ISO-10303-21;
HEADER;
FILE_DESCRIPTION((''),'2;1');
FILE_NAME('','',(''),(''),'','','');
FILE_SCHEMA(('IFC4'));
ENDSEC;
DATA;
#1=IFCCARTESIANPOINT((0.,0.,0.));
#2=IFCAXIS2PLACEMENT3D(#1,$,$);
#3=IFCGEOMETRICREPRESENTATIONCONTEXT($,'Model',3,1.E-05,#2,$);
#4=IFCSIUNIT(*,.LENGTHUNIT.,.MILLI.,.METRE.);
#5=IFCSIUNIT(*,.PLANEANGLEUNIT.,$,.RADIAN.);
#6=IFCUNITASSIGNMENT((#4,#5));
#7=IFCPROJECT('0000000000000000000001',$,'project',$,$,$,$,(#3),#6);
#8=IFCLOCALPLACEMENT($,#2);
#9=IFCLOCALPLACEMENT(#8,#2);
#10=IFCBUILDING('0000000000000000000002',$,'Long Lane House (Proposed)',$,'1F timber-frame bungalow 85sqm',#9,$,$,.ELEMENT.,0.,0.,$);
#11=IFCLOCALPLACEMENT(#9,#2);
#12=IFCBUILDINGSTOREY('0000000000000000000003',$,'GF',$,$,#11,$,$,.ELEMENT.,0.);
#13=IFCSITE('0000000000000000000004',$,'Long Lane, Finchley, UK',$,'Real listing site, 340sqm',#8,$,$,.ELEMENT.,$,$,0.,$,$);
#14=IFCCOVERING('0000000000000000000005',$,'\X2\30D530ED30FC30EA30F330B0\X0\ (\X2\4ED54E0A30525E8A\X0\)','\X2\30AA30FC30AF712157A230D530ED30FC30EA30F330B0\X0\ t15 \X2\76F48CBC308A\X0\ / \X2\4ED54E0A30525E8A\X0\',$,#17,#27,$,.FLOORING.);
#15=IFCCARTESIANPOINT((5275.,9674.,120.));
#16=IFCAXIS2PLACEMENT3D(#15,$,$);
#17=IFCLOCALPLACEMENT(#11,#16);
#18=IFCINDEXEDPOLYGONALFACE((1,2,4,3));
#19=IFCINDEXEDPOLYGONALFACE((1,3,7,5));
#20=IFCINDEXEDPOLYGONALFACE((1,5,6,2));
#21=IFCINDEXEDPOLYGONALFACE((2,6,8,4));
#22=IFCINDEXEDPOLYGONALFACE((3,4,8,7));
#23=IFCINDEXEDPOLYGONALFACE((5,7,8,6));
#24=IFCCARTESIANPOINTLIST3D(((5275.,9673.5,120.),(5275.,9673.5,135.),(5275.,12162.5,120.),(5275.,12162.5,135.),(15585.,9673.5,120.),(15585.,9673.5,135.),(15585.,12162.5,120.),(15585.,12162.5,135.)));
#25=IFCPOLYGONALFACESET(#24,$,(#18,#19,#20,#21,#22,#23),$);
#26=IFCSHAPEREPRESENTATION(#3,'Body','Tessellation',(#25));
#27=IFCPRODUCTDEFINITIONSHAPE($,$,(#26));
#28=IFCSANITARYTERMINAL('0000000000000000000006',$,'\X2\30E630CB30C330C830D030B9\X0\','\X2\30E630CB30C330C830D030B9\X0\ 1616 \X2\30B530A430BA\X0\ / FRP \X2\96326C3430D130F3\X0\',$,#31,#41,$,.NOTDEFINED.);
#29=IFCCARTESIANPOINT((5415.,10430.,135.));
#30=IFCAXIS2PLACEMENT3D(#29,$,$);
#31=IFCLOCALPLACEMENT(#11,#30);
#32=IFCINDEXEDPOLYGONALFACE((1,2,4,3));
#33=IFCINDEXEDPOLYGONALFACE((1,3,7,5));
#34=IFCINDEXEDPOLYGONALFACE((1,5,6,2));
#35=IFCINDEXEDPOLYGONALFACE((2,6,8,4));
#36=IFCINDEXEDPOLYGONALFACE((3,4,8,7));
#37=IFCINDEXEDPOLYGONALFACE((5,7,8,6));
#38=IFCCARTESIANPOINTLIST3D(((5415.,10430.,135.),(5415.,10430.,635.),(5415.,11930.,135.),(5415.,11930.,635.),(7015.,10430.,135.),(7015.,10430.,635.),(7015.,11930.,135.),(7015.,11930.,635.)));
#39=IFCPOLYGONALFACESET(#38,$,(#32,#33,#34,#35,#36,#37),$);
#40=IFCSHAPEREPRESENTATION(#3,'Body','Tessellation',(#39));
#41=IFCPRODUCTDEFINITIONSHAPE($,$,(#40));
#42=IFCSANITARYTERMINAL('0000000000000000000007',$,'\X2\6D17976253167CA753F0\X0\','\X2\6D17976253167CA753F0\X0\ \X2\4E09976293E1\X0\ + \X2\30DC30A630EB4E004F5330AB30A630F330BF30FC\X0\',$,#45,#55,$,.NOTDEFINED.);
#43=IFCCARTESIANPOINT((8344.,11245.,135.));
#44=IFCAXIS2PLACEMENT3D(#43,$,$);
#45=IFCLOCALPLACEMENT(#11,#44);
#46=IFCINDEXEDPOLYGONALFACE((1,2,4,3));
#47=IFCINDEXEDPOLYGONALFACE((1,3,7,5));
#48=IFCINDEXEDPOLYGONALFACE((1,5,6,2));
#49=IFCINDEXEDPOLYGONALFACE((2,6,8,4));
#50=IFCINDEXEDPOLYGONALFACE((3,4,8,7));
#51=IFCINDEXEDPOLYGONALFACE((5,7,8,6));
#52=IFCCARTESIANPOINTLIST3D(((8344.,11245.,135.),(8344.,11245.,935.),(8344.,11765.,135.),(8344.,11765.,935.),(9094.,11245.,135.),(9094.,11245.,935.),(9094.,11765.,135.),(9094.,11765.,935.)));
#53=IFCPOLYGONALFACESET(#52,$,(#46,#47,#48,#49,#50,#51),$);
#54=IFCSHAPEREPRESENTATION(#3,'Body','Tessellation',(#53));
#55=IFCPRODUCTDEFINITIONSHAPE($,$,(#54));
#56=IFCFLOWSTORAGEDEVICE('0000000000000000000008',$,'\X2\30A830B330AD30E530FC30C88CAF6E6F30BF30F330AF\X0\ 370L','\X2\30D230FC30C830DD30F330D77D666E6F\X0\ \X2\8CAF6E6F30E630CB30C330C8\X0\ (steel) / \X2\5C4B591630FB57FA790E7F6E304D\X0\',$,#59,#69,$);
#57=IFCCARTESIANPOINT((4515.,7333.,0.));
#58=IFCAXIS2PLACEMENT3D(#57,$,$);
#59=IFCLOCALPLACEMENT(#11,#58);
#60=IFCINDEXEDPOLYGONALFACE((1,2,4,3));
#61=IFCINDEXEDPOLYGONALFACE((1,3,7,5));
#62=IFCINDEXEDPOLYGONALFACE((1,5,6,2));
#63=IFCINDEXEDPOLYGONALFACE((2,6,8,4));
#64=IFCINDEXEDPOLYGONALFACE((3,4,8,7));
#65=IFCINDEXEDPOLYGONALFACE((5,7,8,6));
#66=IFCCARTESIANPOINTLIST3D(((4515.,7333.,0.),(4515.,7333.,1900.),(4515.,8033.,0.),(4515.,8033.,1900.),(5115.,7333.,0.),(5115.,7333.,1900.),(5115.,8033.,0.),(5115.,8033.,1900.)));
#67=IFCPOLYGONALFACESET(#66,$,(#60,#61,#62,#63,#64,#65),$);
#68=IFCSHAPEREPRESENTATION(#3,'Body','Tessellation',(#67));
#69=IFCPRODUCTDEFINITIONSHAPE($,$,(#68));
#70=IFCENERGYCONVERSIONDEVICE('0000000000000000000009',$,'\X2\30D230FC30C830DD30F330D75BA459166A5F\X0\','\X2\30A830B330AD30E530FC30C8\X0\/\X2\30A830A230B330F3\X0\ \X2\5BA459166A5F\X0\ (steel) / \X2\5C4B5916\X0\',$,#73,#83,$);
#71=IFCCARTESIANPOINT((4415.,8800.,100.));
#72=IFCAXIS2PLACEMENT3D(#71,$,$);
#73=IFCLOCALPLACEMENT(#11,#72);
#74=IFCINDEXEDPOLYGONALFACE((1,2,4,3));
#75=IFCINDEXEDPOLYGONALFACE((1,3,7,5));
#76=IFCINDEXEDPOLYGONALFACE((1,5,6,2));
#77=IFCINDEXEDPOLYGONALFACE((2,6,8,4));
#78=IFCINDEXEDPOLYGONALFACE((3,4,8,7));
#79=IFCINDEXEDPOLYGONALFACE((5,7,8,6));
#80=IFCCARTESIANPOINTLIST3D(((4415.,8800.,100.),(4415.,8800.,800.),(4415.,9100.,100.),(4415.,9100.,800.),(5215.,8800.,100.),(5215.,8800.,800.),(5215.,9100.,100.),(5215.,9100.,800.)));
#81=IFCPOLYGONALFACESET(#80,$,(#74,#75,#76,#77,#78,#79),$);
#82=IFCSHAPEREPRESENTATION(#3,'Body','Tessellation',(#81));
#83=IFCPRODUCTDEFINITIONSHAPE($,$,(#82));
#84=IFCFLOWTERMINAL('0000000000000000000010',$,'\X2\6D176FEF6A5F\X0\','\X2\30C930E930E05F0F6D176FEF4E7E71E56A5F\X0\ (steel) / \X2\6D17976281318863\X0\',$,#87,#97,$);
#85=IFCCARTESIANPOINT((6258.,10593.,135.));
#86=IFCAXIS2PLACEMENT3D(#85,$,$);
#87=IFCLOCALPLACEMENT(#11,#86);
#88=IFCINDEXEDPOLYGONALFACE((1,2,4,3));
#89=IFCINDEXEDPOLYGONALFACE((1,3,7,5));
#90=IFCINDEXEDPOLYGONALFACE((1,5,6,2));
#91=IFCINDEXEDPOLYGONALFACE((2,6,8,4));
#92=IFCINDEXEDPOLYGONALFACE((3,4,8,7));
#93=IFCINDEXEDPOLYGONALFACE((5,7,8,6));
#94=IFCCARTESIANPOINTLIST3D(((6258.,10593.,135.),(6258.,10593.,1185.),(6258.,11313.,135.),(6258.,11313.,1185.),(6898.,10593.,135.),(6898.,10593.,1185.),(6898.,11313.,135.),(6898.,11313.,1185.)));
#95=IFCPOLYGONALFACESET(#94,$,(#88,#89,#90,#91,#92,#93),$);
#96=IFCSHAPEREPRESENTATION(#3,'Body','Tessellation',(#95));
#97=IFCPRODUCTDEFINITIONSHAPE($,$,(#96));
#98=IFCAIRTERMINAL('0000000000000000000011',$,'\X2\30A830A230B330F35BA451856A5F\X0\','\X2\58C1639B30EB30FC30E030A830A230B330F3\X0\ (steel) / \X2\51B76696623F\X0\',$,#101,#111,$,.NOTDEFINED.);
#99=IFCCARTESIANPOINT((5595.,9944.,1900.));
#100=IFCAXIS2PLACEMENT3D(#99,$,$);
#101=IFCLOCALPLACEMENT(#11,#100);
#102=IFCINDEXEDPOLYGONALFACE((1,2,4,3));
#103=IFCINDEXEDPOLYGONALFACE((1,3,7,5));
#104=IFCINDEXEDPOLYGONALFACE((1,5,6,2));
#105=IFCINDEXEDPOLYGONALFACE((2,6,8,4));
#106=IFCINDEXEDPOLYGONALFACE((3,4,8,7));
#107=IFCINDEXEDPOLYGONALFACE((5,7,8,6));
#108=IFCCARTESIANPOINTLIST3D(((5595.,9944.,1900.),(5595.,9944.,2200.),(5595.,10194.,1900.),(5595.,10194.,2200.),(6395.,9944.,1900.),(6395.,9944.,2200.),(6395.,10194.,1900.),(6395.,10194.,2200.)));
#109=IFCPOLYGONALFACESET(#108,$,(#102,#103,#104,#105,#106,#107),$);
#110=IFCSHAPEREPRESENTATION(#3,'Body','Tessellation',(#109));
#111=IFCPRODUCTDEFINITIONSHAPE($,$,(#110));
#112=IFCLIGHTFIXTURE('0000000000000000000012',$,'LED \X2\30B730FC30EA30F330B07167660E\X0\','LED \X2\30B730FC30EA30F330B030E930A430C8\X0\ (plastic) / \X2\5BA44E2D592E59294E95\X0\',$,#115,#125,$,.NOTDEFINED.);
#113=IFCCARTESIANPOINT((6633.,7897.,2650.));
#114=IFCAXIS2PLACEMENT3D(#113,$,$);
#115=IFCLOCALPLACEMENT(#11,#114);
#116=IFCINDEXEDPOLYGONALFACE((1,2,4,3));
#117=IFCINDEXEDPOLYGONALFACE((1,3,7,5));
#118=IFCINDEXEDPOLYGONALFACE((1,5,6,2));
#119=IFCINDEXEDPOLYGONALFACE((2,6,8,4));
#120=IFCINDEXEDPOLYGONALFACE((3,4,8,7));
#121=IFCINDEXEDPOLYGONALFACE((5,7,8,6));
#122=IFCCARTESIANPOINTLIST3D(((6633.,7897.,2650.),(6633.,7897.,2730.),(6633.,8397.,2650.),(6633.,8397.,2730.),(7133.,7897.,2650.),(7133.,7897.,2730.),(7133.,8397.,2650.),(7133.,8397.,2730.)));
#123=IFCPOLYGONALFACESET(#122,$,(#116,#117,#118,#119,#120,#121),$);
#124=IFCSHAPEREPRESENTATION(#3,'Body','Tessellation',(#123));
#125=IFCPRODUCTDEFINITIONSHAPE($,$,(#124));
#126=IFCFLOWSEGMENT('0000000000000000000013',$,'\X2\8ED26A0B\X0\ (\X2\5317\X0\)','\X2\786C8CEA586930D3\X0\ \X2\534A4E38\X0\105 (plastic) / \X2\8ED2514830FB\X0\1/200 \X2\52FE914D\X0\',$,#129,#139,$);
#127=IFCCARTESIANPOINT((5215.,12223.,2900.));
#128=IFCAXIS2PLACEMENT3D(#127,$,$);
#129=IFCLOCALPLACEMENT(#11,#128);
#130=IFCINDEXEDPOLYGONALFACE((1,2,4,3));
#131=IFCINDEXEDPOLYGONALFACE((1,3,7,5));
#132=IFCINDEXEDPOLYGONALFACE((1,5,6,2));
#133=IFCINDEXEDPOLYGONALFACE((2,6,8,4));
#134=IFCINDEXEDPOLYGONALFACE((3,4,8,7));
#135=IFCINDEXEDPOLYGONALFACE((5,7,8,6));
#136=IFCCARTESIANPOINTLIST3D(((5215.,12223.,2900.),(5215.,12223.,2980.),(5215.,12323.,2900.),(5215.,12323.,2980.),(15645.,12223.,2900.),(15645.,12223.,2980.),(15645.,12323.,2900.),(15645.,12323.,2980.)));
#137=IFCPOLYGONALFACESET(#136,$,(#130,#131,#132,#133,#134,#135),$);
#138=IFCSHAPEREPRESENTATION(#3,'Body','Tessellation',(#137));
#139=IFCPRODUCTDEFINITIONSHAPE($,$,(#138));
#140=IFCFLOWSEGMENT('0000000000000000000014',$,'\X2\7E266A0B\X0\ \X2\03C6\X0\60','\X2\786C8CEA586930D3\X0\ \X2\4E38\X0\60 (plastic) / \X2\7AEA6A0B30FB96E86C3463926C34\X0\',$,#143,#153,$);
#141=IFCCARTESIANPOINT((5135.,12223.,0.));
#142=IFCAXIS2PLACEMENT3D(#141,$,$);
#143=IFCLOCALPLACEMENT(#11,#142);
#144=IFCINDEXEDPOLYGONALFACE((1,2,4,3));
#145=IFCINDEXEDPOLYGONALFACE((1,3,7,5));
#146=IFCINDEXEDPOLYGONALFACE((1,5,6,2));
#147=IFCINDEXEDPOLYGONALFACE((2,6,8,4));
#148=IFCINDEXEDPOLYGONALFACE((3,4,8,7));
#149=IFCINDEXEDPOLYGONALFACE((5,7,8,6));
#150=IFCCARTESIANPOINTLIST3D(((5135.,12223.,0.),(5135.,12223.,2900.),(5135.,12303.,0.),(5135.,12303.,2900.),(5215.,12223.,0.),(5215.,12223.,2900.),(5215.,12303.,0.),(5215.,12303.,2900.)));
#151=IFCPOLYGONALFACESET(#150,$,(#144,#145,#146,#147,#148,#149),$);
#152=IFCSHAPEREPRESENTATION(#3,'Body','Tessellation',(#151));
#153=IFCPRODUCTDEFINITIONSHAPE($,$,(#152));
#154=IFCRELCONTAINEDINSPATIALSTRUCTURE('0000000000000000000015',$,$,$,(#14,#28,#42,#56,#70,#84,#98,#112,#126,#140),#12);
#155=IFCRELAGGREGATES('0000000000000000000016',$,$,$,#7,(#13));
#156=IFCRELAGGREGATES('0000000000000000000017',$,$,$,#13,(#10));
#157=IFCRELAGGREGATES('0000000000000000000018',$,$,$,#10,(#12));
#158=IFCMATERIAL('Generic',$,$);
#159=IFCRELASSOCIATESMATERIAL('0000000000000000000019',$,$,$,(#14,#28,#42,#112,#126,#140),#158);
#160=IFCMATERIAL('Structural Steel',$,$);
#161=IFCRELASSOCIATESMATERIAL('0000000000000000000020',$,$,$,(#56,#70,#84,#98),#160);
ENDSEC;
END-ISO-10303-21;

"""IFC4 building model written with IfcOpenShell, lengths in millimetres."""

from ifc_helpers import new_model, si_unit, frame, frame_2d, origin, place, context, project, spatial, rectangle, extrude, material, element, save


model = new_model("IFC4")

# Units and contexts
model_context = context("Model", 3, precision=1e-05, world=origin())
ifc_project = project(units=[si_unit("LENGTHUNIT", "METRE", prefix="MILLI"), si_unit("PLANEANGLEUNIT", "RADIAN")], contexts=[model_context])

# Site, building, storey
site_placement = place(None, origin())
site = spatial("IfcSite", under=ifc_project, at=site_placement, Name="Long Lane, Finchley, UK", ObjectType="Real listing site, 340sqm", CompositionType="ELEMENT", RefElevation=0.0)
building_placement = place(site_placement, origin())
building = spatial("IfcBuilding", under=site, at=building_placement, Name="Long Lane House (Proposed)", ObjectType="1F timber-frame bungalow 85sqm", CompositionType="ELEMENT", ElevationOfRefHeight=0.0, ElevationOfTerrain=0.0)
storey_placement = place(building_placement, origin())
storey = spatial("IfcBuildingStorey", under=building, at=storey_placement, Name="GF", CompositionType="ELEMENT", Elevation=0.0)

# Shared definitions
ifc_material_1 = material(Name="Structural Steel")

# Covering
ifc_material_2 = material(Name="Generic")
covering_1_placement = place(storey_placement, frame((5275.0, 9674.0, 120.0)))
element("IfcCovering", 1, at=covering_1_placement, inside=storey, material=ifc_material_2, Name="フローリング (仕上げ床)", Description="オーク無垢フローリング t15 直貼り / 仕上げ床", PredefinedType="FLOORING", context=model_context, shape_type="SweptSolid", body=[
    extrude(rectangle(XDim=10310.0, YDim=2489.0, at=frame_2d((5155.0, 1244.0))), frame((5275.0, 9674.0, 120.0)), (0.0, 0.0, 1.0), 15.0),
])

# Sanitary terminals
sanitary_terminal_1_placement = place(storey_placement, frame((5415.0, 10430.0, 135.0)))
element("IfcSanitaryTerminal", 2, at=sanitary_terminal_1_placement, inside=storey, material=ifc_material_2, Name="ユニットバス", Description="ユニットバス 1616 サイズ / FRP 防水パン", PredefinedType="NOTDEFINED", context=model_context, shape_type="SweptSolid", body=[
    extrude(rectangle(XDim=1600.0, YDim=1500.0, at=frame_2d((800.0, 750.0))), frame((5415.0, 10430.0, 135.0)), (0.0, 0.0, 1.0), 500.0),
])
sanitary_terminal_2_placement = place(storey_placement, frame((8344.0, 11245.0, 135.0)))
element("IfcSanitaryTerminal", 3, at=sanitary_terminal_2_placement, inside=storey, material=ifc_material_2, Name="洗面化粧台", Description="洗面化粧台 三面鏡 + ボウル一体カウンター", PredefinedType="NOTDEFINED", context=model_context, shape_type="SweptSolid", body=[
    extrude(rectangle(XDim=750.0, YDim=520.0, at=frame_2d((375.0, 260.0))), frame((8344.0, 11245.0, 135.0)), (0.0, 0.0, 1.0), 800.0),
])

# Flow storage device
flow_storage_device_placement = place(storey_placement, frame((4515.0, 7333.0, 0.0)))
element("IfcFlowStorageDevice", 4, at=flow_storage_device_placement, inside=storey, material=ifc_material_1, Name="エコキュート貯湯タンク 370L", Description="ヒートポンプ給湯 貯湯ユニット (steel) / 屋外・基礎置き", context=model_context, shape_type="SweptSolid", body=[
    extrude(rectangle(XDim=600.0, YDim=700.0, at=frame_2d((300.0, 350.0))), frame((4515.0, 7333.0, 0.0)), (0.0, 0.0, 1.0), 1900.0),
])

# Energy conversion device
energy_conversion_device_placement = place(storey_placement, frame((4415.0, 8800.0, 100.0)))
element("IfcEnergyConversionDevice", 5, at=energy_conversion_device_placement, inside=storey, material=ifc_material_1, Name="ヒートポンプ室外機", Description="エコキュート/エアコン 室外機 (steel) / 屋外", context=model_context, shape_type="SweptSolid", body=[
    extrude(rectangle(XDim=800.0, YDim=300.0, at=frame_2d((400.0, 150.0))), frame((4415.0, 8800.0, 100.0)), (0.0, 0.0, 1.0), 700.0),
])

# Flow terminal
flow_terminal_placement = place(storey_placement, frame((6258.0, 10593.0, 135.0)))
element("IfcFlowTerminal", 6, at=flow_terminal_placement, inside=storey, material=ifc_material_1, Name="洗濯機", Description="ドラム式洗濯乾燥機 (steel) / 洗面脱衣", context=model_context, shape_type="SweptSolid", body=[
    extrude(rectangle(XDim=640.0, YDim=720.0, at=frame_2d((320.0, 360.0))), frame((6258.0, 10593.0, 135.0)), (0.0, 0.0, 1.0), 1050.0),
])

# Air terminal
air_terminal_placement = place(storey_placement, frame((5595.0, 9944.0, 1900.0)))
element("IfcAirTerminal", 7, at=air_terminal_placement, inside=storey, material=ifc_material_1, Name="エアコン室内機", Description="壁掛ルームエアコン (steel) / 冷暖房", PredefinedType="NOTDEFINED", context=model_context, shape_type="SweptSolid", body=[
    extrude(rectangle(XDim=800.0, YDim=250.0, at=frame_2d((400.0, 125.0))), frame((5595.0, 9944.0, 1900.0)), (0.0, 0.0, 1.0), 300.0),
])

# Light fixture
light_fixture_placement = place(storey_placement, frame((6633.0, 7897.0, 2650.0)))
element("IfcLightFixture", 8, at=light_fixture_placement, inside=storey, material=ifc_material_2, Name="LED シーリング照明", Description="LED シーリングライト (plastic) / 室中央天井", PredefinedType="NOTDEFINED", context=model_context, shape_type="SweptSolid", body=[
    extrude(rectangle(XDim=500.0, YDim=500.0, at=frame_2d((250.0, 250.0))), frame((6633.0, 7897.0, 2650.0)), (0.0, 0.0, 1.0), 80.0),
])

# Flow segments
flow_segment_1_placement = place(storey_placement, frame((5215.0, 12223.0, 2900.0)))
element("IfcFlowSegment", 9, at=flow_segment_1_placement, inside=storey, material=ifc_material_2, Name="軒樋 (北)", Description="硬質塩ビ 半丸105 (plastic) / 軒先・1/200 勾配", context=model_context, shape_type="SweptSolid", body=[
    extrude(rectangle(XDim=10430.0, YDim=100.0, at=frame_2d((5215.0, 50.0))), frame((5215.0, 12223.0, 2900.0)), (0.0, 0.0, 1.0), 80.0),
])
flow_segment_2_placement = place(storey_placement, frame((5135.0, 12223.0, 0.0)))
element("IfcFlowSegment", 10, at=flow_segment_2_placement, inside=storey, material=ifc_material_2, Name="縦樋 φ60", Description="硬質塩ビ 丸60 (plastic) / 竪樋・雨水排水", context=model_context, shape_type="SweptSolid", body=[
    extrude(rectangle(XDim=80.0, YDim=80.0, at=frame_2d((40.0, 40.0))), frame((5135.0, 12223.0, 0.0)), (0.0, 0.0, 1.0), 2900.0),
])

save(model, "model.ifc")
